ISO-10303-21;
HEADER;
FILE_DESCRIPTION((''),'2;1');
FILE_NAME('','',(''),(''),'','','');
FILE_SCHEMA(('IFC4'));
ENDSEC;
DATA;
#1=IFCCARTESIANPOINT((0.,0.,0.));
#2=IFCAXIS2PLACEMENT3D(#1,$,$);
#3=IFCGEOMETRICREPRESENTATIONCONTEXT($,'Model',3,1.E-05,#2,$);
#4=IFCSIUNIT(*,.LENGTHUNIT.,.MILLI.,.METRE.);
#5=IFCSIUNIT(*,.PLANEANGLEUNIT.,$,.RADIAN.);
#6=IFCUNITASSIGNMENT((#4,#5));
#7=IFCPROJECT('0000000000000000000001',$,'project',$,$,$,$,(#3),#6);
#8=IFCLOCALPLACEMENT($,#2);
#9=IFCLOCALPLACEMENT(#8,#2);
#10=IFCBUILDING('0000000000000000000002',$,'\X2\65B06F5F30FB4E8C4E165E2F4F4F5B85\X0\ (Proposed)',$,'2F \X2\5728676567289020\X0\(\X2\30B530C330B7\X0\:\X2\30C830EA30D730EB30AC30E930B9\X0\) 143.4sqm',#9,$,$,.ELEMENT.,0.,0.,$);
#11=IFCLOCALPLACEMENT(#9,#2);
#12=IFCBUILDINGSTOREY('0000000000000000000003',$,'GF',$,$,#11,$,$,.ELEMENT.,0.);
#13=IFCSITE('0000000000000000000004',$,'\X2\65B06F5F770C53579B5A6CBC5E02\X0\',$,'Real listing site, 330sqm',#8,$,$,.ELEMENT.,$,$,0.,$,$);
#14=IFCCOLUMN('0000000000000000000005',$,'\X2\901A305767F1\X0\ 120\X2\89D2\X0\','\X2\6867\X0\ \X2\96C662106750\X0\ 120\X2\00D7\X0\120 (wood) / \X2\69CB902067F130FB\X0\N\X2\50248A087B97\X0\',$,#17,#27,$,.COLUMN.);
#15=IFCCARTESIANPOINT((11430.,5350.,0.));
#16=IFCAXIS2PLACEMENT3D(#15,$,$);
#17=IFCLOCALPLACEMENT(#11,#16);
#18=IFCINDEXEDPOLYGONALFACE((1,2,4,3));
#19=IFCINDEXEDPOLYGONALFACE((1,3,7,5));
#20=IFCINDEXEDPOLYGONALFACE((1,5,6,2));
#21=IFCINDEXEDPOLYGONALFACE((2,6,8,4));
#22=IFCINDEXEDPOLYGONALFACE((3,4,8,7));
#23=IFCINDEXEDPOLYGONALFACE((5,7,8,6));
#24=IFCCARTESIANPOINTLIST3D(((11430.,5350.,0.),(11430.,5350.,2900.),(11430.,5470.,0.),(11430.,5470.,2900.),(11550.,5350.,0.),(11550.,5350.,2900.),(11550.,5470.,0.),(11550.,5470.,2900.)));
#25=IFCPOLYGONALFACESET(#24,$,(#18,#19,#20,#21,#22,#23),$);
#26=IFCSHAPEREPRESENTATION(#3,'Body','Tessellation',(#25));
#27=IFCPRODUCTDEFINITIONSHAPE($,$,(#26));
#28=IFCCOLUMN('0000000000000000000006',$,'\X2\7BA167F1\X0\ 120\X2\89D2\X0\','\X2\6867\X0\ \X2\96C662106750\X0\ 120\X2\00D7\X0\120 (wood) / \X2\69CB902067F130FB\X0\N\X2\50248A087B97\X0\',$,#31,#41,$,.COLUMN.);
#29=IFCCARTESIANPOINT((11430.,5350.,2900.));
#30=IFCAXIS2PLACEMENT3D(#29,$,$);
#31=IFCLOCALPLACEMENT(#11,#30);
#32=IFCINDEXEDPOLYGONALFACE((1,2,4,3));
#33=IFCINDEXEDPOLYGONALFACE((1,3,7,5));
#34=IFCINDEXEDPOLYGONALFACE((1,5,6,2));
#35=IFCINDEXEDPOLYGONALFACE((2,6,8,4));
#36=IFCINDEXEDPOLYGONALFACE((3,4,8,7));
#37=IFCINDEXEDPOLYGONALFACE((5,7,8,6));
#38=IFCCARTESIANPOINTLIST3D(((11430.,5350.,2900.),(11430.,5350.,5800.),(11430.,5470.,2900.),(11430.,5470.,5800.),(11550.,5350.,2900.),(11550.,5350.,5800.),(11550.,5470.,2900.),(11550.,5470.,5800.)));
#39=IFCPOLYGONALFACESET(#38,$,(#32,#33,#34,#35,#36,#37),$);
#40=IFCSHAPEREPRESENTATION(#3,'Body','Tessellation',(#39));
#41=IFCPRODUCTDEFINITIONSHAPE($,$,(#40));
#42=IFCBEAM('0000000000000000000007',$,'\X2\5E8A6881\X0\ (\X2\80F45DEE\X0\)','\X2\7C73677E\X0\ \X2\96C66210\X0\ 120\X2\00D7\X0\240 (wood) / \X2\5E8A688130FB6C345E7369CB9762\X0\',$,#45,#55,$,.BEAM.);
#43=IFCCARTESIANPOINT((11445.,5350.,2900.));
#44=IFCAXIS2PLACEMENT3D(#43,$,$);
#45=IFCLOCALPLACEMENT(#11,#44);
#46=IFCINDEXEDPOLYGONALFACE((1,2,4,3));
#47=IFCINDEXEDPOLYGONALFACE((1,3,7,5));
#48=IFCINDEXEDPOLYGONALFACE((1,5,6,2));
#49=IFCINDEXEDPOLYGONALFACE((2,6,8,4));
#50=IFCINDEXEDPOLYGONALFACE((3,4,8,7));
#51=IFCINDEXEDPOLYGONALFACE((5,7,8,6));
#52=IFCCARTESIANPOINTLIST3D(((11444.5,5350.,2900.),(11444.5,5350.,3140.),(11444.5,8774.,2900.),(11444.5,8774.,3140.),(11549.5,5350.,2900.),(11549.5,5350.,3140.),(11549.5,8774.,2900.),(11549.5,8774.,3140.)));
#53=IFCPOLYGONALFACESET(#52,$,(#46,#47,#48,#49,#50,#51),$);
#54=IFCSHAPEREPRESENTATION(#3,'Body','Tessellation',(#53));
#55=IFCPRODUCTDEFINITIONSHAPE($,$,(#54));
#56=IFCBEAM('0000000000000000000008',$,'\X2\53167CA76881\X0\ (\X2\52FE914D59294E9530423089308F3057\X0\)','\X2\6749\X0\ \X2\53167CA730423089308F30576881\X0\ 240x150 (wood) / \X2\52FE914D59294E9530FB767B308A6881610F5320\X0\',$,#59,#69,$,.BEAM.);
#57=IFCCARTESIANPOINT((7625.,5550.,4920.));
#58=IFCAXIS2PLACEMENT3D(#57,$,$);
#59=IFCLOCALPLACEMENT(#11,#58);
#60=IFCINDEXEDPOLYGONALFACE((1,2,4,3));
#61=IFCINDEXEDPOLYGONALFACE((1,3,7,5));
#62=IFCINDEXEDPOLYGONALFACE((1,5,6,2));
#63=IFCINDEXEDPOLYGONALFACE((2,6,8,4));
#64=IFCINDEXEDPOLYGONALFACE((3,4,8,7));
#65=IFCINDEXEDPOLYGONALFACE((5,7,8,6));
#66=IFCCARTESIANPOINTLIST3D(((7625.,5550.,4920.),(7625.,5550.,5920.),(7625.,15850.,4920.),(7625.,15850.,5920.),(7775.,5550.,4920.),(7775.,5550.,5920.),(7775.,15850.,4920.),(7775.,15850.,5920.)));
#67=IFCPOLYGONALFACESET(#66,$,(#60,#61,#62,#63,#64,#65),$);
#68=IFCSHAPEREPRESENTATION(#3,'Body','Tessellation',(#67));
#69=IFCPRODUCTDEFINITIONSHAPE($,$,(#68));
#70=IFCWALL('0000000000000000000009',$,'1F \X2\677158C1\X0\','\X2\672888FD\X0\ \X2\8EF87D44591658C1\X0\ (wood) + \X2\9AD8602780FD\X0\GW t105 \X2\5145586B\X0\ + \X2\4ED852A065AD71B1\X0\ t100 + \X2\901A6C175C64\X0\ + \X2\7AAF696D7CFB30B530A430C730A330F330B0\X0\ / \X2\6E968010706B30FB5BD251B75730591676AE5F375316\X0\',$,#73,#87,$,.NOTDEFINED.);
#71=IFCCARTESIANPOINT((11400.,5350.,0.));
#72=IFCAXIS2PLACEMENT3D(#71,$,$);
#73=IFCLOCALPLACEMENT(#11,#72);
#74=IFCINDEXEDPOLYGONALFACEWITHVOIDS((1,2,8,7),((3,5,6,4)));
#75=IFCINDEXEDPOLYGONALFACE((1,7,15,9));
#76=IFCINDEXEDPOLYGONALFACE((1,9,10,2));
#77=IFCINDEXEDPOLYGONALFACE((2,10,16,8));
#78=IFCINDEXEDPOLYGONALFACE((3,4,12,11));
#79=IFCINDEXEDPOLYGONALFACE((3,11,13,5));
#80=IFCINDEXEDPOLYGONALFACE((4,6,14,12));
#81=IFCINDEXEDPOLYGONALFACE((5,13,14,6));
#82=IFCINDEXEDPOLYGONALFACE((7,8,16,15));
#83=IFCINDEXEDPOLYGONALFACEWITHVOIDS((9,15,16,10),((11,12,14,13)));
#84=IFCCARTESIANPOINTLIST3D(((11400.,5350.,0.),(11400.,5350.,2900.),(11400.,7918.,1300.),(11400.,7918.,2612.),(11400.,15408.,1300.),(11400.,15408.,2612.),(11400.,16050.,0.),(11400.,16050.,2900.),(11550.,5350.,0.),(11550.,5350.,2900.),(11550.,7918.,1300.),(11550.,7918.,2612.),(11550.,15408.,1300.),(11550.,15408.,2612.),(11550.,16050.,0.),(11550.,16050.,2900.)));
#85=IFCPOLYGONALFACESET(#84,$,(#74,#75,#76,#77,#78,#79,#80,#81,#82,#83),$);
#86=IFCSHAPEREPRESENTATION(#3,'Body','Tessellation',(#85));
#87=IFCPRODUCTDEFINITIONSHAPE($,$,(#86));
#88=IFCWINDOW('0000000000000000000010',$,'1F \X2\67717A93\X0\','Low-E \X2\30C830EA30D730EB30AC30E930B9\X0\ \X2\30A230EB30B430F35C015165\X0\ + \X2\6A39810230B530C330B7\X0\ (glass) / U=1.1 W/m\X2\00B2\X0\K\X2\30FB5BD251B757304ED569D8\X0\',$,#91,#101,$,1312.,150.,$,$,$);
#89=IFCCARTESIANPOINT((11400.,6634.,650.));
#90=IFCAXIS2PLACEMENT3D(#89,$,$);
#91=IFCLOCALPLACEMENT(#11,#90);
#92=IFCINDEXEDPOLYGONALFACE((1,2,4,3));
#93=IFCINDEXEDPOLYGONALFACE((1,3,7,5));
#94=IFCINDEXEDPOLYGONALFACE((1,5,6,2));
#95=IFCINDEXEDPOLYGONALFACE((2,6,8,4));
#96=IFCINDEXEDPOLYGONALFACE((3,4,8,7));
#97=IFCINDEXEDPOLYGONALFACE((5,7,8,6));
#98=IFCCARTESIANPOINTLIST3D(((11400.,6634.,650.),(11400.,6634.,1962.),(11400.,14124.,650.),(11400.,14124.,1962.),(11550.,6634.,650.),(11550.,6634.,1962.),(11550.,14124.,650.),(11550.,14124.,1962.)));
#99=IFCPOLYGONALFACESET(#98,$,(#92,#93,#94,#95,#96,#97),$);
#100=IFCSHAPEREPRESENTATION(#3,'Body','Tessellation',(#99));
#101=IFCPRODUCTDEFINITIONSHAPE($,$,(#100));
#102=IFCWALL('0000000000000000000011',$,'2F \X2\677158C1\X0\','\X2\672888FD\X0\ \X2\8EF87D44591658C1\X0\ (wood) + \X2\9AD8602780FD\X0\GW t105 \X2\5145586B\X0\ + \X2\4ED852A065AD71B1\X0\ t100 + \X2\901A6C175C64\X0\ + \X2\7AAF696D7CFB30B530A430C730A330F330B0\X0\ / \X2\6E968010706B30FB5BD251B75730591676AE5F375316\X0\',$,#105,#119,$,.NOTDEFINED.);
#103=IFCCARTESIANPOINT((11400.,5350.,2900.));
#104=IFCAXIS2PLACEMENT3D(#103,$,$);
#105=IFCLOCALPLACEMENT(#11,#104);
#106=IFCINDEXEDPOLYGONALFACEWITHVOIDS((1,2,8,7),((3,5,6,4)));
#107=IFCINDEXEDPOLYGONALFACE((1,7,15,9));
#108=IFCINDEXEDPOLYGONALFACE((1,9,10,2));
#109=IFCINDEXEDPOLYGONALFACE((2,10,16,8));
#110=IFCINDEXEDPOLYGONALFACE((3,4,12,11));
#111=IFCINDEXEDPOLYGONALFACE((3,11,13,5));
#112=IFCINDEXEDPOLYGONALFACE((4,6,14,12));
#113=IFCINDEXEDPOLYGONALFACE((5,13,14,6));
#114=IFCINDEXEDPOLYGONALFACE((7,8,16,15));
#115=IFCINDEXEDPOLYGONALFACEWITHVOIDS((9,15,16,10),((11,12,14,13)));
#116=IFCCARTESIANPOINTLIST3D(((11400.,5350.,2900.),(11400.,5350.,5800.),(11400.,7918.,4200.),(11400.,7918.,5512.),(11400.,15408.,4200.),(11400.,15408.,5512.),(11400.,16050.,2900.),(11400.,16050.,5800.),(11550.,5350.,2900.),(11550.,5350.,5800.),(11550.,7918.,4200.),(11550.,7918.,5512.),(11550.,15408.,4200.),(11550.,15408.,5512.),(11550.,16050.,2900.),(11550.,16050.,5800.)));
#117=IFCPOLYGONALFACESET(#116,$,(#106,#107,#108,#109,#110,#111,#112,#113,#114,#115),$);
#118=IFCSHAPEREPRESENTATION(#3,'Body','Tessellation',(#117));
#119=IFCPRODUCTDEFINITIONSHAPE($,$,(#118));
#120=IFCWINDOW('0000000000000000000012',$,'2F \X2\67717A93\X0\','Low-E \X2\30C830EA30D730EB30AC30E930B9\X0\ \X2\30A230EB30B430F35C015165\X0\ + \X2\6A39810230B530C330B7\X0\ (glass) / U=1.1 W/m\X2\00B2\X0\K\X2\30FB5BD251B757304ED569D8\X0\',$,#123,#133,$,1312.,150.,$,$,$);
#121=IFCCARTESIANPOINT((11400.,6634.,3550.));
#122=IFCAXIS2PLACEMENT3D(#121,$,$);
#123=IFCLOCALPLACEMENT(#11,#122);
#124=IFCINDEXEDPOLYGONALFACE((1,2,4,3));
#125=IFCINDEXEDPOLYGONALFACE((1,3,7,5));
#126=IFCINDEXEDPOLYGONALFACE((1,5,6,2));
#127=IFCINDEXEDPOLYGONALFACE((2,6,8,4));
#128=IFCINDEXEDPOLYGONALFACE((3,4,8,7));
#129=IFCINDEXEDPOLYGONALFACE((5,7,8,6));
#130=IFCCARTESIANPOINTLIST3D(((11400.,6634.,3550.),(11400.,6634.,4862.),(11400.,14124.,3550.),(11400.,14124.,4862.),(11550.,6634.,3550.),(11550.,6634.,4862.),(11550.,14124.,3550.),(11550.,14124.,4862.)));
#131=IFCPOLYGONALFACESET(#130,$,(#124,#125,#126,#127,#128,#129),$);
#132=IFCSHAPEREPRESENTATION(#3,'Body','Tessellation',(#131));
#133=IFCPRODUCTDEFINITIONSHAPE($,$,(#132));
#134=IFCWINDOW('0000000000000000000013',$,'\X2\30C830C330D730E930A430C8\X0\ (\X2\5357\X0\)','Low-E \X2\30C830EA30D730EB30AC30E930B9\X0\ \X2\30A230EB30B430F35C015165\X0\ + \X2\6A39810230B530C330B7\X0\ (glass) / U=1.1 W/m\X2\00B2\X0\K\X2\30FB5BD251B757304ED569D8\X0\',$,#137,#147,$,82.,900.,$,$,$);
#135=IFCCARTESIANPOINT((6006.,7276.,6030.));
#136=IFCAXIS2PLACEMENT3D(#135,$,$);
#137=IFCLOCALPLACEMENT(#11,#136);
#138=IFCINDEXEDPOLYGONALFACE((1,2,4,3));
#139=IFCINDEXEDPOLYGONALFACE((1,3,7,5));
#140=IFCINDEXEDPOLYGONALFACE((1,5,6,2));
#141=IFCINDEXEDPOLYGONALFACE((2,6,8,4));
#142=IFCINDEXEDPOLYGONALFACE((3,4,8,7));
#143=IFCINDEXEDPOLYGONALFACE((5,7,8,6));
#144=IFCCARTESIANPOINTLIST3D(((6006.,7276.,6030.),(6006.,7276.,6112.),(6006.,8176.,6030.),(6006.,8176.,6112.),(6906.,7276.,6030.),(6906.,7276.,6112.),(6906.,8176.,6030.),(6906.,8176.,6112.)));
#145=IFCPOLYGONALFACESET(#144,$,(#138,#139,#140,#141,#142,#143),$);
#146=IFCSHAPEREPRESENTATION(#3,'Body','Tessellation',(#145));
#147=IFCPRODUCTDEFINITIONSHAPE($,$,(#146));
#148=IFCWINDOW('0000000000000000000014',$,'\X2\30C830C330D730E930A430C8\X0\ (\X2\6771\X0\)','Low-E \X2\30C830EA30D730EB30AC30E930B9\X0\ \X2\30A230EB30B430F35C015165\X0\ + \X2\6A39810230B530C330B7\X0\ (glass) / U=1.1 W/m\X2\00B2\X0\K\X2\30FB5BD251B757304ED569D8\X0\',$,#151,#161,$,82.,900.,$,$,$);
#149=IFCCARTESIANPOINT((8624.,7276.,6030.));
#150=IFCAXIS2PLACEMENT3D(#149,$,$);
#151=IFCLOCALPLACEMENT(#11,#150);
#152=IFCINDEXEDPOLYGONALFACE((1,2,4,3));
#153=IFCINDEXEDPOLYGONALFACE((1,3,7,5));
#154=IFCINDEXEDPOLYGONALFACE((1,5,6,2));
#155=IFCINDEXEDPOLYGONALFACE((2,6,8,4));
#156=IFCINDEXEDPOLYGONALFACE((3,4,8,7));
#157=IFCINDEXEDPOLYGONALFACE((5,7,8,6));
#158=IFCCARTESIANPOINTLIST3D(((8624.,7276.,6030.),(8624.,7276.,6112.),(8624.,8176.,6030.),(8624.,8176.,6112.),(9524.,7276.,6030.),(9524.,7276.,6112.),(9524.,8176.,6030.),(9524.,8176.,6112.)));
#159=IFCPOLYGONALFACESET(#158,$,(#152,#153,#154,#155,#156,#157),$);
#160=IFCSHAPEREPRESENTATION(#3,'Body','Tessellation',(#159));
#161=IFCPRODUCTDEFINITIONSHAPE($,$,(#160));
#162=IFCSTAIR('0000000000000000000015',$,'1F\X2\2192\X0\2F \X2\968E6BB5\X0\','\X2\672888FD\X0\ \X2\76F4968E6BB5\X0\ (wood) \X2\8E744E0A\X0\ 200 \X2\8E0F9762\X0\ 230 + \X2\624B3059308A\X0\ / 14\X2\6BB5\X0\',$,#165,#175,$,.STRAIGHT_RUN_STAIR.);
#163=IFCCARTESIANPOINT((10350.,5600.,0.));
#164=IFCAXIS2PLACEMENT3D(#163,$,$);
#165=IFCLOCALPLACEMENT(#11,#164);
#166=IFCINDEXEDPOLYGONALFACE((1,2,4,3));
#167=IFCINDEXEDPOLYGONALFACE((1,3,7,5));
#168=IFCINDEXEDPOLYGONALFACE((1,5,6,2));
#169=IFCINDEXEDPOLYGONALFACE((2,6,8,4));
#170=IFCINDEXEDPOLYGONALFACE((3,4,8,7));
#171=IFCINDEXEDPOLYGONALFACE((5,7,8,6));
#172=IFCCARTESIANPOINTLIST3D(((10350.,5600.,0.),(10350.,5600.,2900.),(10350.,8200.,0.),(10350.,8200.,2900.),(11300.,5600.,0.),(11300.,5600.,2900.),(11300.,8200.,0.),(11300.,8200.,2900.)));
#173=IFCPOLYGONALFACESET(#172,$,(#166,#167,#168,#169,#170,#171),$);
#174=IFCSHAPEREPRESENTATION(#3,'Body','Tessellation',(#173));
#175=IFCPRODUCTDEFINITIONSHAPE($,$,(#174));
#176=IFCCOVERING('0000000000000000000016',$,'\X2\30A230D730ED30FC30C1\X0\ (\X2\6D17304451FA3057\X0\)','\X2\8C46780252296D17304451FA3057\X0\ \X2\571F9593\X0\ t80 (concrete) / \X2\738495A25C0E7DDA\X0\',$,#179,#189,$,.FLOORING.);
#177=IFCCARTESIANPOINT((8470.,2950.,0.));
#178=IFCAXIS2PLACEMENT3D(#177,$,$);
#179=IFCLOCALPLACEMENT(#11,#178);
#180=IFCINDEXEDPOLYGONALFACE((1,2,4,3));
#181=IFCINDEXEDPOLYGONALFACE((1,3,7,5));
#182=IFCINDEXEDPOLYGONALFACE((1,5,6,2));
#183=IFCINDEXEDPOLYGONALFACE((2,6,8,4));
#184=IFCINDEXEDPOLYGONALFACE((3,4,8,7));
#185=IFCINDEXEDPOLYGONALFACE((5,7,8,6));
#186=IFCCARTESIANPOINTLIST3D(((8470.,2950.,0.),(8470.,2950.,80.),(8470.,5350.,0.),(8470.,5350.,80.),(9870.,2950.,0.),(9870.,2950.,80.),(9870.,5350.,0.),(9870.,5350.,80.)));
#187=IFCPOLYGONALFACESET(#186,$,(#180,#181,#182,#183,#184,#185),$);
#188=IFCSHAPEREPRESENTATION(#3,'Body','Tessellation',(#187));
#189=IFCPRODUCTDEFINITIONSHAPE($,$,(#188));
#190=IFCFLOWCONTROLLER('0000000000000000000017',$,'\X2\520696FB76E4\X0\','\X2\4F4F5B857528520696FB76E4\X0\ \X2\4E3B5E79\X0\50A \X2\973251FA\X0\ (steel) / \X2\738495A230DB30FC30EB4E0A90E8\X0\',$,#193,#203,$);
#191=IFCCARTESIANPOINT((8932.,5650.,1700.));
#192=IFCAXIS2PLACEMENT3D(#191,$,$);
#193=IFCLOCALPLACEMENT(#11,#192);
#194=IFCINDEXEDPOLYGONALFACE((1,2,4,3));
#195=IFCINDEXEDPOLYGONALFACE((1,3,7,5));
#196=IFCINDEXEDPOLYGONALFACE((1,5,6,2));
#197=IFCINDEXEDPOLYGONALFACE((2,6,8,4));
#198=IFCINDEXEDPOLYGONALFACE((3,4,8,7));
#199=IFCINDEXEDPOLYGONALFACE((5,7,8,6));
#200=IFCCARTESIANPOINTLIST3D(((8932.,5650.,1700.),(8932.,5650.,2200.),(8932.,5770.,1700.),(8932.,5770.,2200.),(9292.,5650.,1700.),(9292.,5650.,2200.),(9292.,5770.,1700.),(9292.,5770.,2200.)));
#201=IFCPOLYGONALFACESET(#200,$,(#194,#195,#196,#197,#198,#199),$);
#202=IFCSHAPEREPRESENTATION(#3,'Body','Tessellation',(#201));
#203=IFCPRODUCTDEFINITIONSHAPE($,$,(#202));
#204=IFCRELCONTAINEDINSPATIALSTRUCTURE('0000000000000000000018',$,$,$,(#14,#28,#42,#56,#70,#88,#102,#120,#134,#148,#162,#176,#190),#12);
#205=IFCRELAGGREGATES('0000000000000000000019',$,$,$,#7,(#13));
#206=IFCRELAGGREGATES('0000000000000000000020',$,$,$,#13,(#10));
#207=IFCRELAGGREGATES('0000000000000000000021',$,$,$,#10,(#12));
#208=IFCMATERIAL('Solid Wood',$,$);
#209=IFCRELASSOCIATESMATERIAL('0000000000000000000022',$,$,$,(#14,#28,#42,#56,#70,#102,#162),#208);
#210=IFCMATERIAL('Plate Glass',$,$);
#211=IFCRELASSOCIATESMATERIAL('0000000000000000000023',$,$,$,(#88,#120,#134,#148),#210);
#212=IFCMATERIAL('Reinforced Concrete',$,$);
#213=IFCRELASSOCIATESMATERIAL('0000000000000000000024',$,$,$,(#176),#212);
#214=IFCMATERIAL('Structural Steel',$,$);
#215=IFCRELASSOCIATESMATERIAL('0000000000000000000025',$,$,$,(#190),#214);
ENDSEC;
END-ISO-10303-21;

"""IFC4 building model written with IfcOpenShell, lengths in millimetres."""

from ifc_helpers import new_model, si_unit, frame, frame_2d, origin, place, context, project, spatial, rectangle, extrude, material, element, fill, save


model = new_model("IFC4")

# Units and contexts
model_context = context("Model", 3, precision=1e-05, world=origin())
ifc_project = project(units=[si_unit("LENGTHUNIT", "METRE", prefix="MILLI"), si_unit("PLANEANGLEUNIT", "RADIAN")], contexts=[model_context])

# Site, building, storey
site_placement = place(None, origin())
site = spatial("IfcSite", under=ifc_project, at=site_placement, Name="新潟県南魚沼市", ObjectType="Real listing site, 330sqm", CompositionType="ELEMENT", RefElevation=0.0)
building_placement = place(site_placement, origin())
building = spatial("IfcBuilding", under=site, at=building_placement, Name="新潟・二世帯住宅 (Proposed)", ObjectType="2F 在来木造(サッシ:トリプルガラス) 143.4sqm", CompositionType="ELEMENT", ElevationOfRefHeight=0.0, ElevationOfTerrain=0.0)
storey_placement = place(building_placement, origin())
storey = spatial("IfcBuildingStorey", under=building, at=storey_placement, Name="GF", CompositionType="ELEMENT", Elevation=0.0)

# Columns
ifc_material_1 = material(Name="Solid Wood")
column_1_placement = place(storey_placement, frame((11430.0, 5350.0, 0.0)))
element("IfcColumn", 1, at=column_1_placement, inside=storey, material=ifc_material_1, Name="通し柱 120角", Description="桧 集成材 120×120 (wood) / 構造柱・N値計算", PredefinedType="COLUMN", context=model_context, shape_type="SweptSolid", body=[
    extrude(rectangle(XDim=120.0, YDim=120.0, at=frame_2d((60.0, 60.0))), frame((11430.0, 5350.0, 0.0)), (0.0, 0.0, 1.0), 2900.0),
])
column_2_placement = place(storey_placement, frame((11430.0, 5350.0, 2900.0)))
element("IfcColumn", 2, at=column_2_placement, inside=storey, material=ifc_material_1, Name="管柱 120角", Description="桧 集成材 120×120 (wood) / 構造柱・N値計算", PredefinedType="COLUMN", context=model_context, shape_type="SweptSolid", body=[
    extrude(rectangle(XDim=120.0, YDim=120.0, at=frame_2d((60.0, 60.0))), frame((11430.0, 5350.0, 2900.0)), (0.0, 0.0, 1.0), 2900.0),
])

# Beams
beam_1_placement = place(storey_placement, frame((11445.0, 5350.0, 2900.0)))
element("IfcBeam", 3, at=beam_1_placement, inside=storey, material=ifc_material_1, Name="床梁 (胴差)", Description="米松 集成 120×240 (wood) / 床梁・水平構面", PredefinedType="BEAM", context=model_context, shape_type="SweptSolid", body=[
    extrude(rectangle(XDim=105.0, YDim=3424.0, at=frame_2d((52.0, 1712.0))), frame((11445.0, 5350.0, 2900.0)), (0.0, 0.0, 1.0), 240.0),
])
beam_2_placement = place(storey_placement, frame((7625.0, 5550.0, 4920.0)))
element("IfcBeam", 4, at=beam_2_placement, inside=storey, material=ifc_material_1, Name="化粧梁 (勾配天井あらわし)", Description="杉 化粧あらわし梁 240x150 (wood) / 勾配天井・登り梁意匠", PredefinedType="BEAM", context=model_context, shape_type="SweptSolid", body=[
    extrude(rectangle(XDim=150.0, YDim=10300.0, at=frame_2d((75.0, 5150.0))), frame((7625.0, 5550.0, 4920.0)), (0.0, 0.0, 1.0), 1000.0),
])

# Wall, opening, window
wall_1_placement = place(storey_placement, frame((11400.0, 5350.0, 0.0)))
wall_1 = element("IfcWall", 5, at=wall_1_placement, inside=storey, material=ifc_material_1, Name="1F 東壁", Description="木製 軸組外壁 (wood) + 高性能GW t105 充填 + 付加断熱 t100 + 通気層 + 窯業系サイディング / 準耐火・寒冷地外皮強化", PredefinedType="NOTDEFINED", context=model_context, shape_type="SweptSolid", body=[
    extrude(rectangle(XDim=150.0, YDim=10700.0, at=frame_2d((75.0, 5350.0))), frame((11400.0, 5350.0, 0.0)), (0.0, 0.0, 1.0), 2900.0),
])
opening_1_placement = place(storey_placement, frame((11400.0, 6634.0, 650.0)))
opening_1 = element("IfcOpeningElement", 6, at=opening_1_placement, cuts=wall_1, PredefinedType="NOTDEFINED", context=model_context, shape_type="SweptSolid", body=[
    extrude(rectangle(XDim=150.0, YDim=7490.0, at=frame_2d((75.0, 3745.0))), frame((11400.0, 6634.0, 650.0)), (0.0, 0.0, 1.0), 1312.0),
])
ifc_material_2 = material(Name="Plate Glass")
window_1_placement = place(storey_placement, frame((11400.0, 6634.0, 650.0)))
window_1 = element("IfcWindow", 7, at=window_1_placement, inside=storey, material=ifc_material_2, Name="1F 東窓", Description="Low-E トリプルガラス アルゴン封入 + 樹脂サッシ (glass) / U=1.1 W/m²K・寒冷地仕様", OverallHeight=1312.0, OverallWidth=150.0, context=model_context, shape_type="SweptSolid", body=[
    extrude(rectangle(XDim=150.0, YDim=7490.0, at=frame_2d((75.0, 3745.0))), frame((11400.0, 6634.0, 650.0)), (0.0, 0.0, 1.0), 1312.0),
])
fill(opening_1, window_1)

# Wall, opening, window
wall_2_placement = place(storey_placement, frame((11400.0, 5350.0, 2900.0)))
wall_2 = element("IfcWall", 8, at=wall_2_placement, inside=storey, material=ifc_material_1, Name="2F 東壁", Description="木製 軸組外壁 (wood) + 高性能GW t105 充填 + 付加断熱 t100 + 通気層 + 窯業系サイディング / 準耐火・寒冷地外皮強化", PredefinedType="NOTDEFINED", context=model_context, shape_type="SweptSolid", body=[
    extrude(rectangle(XDim=150.0, YDim=10700.0, at=frame_2d((75.0, 5350.0))), frame((11400.0, 5350.0, 2900.0)), (0.0, 0.0, 1.0), 2900.0),
])
opening_2_placement = place(storey_placement, frame((11400.0, 6634.0, 3550.0)))
opening_2 = element("IfcOpeningElement", 9, at=opening_2_placement, cuts=wall_2, PredefinedType="NOTDEFINED", context=model_context, shape_type="SweptSolid", body=[
    extrude(rectangle(XDim=150.0, YDim=7490.0, at=frame_2d((75.0, 3745.0))), frame((11400.0, 6634.0, 3550.0)), (0.0, 0.0, 1.0), 1312.0),
])
window_2_placement = place(storey_placement, frame((11400.0, 6634.0, 3550.0)))
window_2 = element("IfcWindow", 10, at=window_2_placement, inside=storey, material=ifc_material_2, Name="2F 東窓", Description="Low-E トリプルガラス アルゴン封入 + 樹脂サッシ (glass) / U=1.1 W/m²K・寒冷地仕様", OverallHeight=1312.0, OverallWidth=150.0, context=model_context, shape_type="SweptSolid", body=[
    extrude(rectangle(XDim=150.0, YDim=7490.0, at=frame_2d((75.0, 3745.0))), frame((11400.0, 6634.0, 3550.0)), (0.0, 0.0, 1.0), 1312.0),
])
fill(opening_2, window_2)

# Windows
window_3_placement = place(storey_placement, frame((6006.0, 7276.0, 6030.0)))
element("IfcWindow", 11, at=window_3_placement, inside=storey, material=ifc_material_2, Name="トップライト (南)", Description="Low-E トリプルガラス アルゴン封入 + 樹脂サッシ (glass) / U=1.1 W/m²K・寒冷地仕様", OverallHeight=82.0, OverallWidth=900.0, context=model_context, shape_type="SweptSolid", body=[
    extrude(rectangle(XDim=900.0, YDim=900.0, at=frame_2d((450.0, 450.0))), frame((6006.0, 7276.0, 6030.0)), (0.0, 0.0, 1.0), 82.0),
])
window_4_placement = place(storey_placement, frame((8624.0, 7276.0, 6030.0)))
element("IfcWindow", 12, at=window_4_placement, inside=storey, material=ifc_material_2, Name="トップライト (東)", Description="Low-E トリプルガラス アルゴン封入 + 樹脂サッシ (glass) / U=1.1 W/m²K・寒冷地仕様", OverallHeight=82.0, OverallWidth=900.0, context=model_context, shape_type="SweptSolid", body=[
    extrude(rectangle(XDim=900.0, YDim=900.0, at=frame_2d((450.0, 450.0))), frame((8624.0, 7276.0, 6030.0)), (0.0, 0.0, 1.0), 82.0),
])

# Stair
stair_placement = place(storey_placement, frame((10350.0, 5600.0, 0.0)))
element("IfcStair", 13, at=stair_placement, inside=storey, material=ifc_material_1, Name="1F→2F 階段", Description="木製 直階段 (wood) 蹴上 200 踏面 230 + 手すり / 14段", PredefinedType="STRAIGHT_RUN_STAIR", context=model_context, shape_type="SweptSolid", body=[
    extrude(rectangle(XDim=950.0, YDim=2600.0, at=frame_2d((475.0, 1300.0))), frame((10350.0, 5600.0, 0.0)), (0.0, 0.0, 1.0), 2900.0),
])

# Covering
ifc_material_3 = material(Name="Reinforced Concrete")
covering_placement = place(storey_placement, frame((8470.0, 2950.0, 0.0)))
element("IfcCovering", 14, at=covering_placement, inside=storey, material=ifc_material_3, Name="アプローチ (洗い出し)", Description="豆砂利洗い出し 土間 t80 (concrete) / 玄関導線", PredefinedType="FLOORING", context=model_context, shape_type="SweptSolid", body=[
    extrude(rectangle(XDim=1400.0, YDim=2400.0, at=frame_2d((700.0, 1200.0))), frame((8470.0, 2950.0, 0.0)), (0.0, 0.0, 1.0), 80.0),
])

# Flow controller
ifc_material_4 = material(Name="Structural Steel")
flow_controller_placement = place(storey_placement, frame((8932.0, 5650.0, 1700.0)))
element("IfcFlowController", 15, at=flow_controller_placement, inside=storey, material=ifc_material_4, Name="分電盤", Description="住宅用分電盤 主幹50A 露出 (steel) / 玄関ホール上部", context=model_context, shape_type="SweptSolid", body=[
    extrude(rectangle(XDim=360.0, YDim=120.0, at=frame_2d((180.0, 60.0))), frame((8932.0, 5650.0, 1700.0)), (0.0, 0.0, 1.0), 500.0),
])

save(model, "model.ifc")
